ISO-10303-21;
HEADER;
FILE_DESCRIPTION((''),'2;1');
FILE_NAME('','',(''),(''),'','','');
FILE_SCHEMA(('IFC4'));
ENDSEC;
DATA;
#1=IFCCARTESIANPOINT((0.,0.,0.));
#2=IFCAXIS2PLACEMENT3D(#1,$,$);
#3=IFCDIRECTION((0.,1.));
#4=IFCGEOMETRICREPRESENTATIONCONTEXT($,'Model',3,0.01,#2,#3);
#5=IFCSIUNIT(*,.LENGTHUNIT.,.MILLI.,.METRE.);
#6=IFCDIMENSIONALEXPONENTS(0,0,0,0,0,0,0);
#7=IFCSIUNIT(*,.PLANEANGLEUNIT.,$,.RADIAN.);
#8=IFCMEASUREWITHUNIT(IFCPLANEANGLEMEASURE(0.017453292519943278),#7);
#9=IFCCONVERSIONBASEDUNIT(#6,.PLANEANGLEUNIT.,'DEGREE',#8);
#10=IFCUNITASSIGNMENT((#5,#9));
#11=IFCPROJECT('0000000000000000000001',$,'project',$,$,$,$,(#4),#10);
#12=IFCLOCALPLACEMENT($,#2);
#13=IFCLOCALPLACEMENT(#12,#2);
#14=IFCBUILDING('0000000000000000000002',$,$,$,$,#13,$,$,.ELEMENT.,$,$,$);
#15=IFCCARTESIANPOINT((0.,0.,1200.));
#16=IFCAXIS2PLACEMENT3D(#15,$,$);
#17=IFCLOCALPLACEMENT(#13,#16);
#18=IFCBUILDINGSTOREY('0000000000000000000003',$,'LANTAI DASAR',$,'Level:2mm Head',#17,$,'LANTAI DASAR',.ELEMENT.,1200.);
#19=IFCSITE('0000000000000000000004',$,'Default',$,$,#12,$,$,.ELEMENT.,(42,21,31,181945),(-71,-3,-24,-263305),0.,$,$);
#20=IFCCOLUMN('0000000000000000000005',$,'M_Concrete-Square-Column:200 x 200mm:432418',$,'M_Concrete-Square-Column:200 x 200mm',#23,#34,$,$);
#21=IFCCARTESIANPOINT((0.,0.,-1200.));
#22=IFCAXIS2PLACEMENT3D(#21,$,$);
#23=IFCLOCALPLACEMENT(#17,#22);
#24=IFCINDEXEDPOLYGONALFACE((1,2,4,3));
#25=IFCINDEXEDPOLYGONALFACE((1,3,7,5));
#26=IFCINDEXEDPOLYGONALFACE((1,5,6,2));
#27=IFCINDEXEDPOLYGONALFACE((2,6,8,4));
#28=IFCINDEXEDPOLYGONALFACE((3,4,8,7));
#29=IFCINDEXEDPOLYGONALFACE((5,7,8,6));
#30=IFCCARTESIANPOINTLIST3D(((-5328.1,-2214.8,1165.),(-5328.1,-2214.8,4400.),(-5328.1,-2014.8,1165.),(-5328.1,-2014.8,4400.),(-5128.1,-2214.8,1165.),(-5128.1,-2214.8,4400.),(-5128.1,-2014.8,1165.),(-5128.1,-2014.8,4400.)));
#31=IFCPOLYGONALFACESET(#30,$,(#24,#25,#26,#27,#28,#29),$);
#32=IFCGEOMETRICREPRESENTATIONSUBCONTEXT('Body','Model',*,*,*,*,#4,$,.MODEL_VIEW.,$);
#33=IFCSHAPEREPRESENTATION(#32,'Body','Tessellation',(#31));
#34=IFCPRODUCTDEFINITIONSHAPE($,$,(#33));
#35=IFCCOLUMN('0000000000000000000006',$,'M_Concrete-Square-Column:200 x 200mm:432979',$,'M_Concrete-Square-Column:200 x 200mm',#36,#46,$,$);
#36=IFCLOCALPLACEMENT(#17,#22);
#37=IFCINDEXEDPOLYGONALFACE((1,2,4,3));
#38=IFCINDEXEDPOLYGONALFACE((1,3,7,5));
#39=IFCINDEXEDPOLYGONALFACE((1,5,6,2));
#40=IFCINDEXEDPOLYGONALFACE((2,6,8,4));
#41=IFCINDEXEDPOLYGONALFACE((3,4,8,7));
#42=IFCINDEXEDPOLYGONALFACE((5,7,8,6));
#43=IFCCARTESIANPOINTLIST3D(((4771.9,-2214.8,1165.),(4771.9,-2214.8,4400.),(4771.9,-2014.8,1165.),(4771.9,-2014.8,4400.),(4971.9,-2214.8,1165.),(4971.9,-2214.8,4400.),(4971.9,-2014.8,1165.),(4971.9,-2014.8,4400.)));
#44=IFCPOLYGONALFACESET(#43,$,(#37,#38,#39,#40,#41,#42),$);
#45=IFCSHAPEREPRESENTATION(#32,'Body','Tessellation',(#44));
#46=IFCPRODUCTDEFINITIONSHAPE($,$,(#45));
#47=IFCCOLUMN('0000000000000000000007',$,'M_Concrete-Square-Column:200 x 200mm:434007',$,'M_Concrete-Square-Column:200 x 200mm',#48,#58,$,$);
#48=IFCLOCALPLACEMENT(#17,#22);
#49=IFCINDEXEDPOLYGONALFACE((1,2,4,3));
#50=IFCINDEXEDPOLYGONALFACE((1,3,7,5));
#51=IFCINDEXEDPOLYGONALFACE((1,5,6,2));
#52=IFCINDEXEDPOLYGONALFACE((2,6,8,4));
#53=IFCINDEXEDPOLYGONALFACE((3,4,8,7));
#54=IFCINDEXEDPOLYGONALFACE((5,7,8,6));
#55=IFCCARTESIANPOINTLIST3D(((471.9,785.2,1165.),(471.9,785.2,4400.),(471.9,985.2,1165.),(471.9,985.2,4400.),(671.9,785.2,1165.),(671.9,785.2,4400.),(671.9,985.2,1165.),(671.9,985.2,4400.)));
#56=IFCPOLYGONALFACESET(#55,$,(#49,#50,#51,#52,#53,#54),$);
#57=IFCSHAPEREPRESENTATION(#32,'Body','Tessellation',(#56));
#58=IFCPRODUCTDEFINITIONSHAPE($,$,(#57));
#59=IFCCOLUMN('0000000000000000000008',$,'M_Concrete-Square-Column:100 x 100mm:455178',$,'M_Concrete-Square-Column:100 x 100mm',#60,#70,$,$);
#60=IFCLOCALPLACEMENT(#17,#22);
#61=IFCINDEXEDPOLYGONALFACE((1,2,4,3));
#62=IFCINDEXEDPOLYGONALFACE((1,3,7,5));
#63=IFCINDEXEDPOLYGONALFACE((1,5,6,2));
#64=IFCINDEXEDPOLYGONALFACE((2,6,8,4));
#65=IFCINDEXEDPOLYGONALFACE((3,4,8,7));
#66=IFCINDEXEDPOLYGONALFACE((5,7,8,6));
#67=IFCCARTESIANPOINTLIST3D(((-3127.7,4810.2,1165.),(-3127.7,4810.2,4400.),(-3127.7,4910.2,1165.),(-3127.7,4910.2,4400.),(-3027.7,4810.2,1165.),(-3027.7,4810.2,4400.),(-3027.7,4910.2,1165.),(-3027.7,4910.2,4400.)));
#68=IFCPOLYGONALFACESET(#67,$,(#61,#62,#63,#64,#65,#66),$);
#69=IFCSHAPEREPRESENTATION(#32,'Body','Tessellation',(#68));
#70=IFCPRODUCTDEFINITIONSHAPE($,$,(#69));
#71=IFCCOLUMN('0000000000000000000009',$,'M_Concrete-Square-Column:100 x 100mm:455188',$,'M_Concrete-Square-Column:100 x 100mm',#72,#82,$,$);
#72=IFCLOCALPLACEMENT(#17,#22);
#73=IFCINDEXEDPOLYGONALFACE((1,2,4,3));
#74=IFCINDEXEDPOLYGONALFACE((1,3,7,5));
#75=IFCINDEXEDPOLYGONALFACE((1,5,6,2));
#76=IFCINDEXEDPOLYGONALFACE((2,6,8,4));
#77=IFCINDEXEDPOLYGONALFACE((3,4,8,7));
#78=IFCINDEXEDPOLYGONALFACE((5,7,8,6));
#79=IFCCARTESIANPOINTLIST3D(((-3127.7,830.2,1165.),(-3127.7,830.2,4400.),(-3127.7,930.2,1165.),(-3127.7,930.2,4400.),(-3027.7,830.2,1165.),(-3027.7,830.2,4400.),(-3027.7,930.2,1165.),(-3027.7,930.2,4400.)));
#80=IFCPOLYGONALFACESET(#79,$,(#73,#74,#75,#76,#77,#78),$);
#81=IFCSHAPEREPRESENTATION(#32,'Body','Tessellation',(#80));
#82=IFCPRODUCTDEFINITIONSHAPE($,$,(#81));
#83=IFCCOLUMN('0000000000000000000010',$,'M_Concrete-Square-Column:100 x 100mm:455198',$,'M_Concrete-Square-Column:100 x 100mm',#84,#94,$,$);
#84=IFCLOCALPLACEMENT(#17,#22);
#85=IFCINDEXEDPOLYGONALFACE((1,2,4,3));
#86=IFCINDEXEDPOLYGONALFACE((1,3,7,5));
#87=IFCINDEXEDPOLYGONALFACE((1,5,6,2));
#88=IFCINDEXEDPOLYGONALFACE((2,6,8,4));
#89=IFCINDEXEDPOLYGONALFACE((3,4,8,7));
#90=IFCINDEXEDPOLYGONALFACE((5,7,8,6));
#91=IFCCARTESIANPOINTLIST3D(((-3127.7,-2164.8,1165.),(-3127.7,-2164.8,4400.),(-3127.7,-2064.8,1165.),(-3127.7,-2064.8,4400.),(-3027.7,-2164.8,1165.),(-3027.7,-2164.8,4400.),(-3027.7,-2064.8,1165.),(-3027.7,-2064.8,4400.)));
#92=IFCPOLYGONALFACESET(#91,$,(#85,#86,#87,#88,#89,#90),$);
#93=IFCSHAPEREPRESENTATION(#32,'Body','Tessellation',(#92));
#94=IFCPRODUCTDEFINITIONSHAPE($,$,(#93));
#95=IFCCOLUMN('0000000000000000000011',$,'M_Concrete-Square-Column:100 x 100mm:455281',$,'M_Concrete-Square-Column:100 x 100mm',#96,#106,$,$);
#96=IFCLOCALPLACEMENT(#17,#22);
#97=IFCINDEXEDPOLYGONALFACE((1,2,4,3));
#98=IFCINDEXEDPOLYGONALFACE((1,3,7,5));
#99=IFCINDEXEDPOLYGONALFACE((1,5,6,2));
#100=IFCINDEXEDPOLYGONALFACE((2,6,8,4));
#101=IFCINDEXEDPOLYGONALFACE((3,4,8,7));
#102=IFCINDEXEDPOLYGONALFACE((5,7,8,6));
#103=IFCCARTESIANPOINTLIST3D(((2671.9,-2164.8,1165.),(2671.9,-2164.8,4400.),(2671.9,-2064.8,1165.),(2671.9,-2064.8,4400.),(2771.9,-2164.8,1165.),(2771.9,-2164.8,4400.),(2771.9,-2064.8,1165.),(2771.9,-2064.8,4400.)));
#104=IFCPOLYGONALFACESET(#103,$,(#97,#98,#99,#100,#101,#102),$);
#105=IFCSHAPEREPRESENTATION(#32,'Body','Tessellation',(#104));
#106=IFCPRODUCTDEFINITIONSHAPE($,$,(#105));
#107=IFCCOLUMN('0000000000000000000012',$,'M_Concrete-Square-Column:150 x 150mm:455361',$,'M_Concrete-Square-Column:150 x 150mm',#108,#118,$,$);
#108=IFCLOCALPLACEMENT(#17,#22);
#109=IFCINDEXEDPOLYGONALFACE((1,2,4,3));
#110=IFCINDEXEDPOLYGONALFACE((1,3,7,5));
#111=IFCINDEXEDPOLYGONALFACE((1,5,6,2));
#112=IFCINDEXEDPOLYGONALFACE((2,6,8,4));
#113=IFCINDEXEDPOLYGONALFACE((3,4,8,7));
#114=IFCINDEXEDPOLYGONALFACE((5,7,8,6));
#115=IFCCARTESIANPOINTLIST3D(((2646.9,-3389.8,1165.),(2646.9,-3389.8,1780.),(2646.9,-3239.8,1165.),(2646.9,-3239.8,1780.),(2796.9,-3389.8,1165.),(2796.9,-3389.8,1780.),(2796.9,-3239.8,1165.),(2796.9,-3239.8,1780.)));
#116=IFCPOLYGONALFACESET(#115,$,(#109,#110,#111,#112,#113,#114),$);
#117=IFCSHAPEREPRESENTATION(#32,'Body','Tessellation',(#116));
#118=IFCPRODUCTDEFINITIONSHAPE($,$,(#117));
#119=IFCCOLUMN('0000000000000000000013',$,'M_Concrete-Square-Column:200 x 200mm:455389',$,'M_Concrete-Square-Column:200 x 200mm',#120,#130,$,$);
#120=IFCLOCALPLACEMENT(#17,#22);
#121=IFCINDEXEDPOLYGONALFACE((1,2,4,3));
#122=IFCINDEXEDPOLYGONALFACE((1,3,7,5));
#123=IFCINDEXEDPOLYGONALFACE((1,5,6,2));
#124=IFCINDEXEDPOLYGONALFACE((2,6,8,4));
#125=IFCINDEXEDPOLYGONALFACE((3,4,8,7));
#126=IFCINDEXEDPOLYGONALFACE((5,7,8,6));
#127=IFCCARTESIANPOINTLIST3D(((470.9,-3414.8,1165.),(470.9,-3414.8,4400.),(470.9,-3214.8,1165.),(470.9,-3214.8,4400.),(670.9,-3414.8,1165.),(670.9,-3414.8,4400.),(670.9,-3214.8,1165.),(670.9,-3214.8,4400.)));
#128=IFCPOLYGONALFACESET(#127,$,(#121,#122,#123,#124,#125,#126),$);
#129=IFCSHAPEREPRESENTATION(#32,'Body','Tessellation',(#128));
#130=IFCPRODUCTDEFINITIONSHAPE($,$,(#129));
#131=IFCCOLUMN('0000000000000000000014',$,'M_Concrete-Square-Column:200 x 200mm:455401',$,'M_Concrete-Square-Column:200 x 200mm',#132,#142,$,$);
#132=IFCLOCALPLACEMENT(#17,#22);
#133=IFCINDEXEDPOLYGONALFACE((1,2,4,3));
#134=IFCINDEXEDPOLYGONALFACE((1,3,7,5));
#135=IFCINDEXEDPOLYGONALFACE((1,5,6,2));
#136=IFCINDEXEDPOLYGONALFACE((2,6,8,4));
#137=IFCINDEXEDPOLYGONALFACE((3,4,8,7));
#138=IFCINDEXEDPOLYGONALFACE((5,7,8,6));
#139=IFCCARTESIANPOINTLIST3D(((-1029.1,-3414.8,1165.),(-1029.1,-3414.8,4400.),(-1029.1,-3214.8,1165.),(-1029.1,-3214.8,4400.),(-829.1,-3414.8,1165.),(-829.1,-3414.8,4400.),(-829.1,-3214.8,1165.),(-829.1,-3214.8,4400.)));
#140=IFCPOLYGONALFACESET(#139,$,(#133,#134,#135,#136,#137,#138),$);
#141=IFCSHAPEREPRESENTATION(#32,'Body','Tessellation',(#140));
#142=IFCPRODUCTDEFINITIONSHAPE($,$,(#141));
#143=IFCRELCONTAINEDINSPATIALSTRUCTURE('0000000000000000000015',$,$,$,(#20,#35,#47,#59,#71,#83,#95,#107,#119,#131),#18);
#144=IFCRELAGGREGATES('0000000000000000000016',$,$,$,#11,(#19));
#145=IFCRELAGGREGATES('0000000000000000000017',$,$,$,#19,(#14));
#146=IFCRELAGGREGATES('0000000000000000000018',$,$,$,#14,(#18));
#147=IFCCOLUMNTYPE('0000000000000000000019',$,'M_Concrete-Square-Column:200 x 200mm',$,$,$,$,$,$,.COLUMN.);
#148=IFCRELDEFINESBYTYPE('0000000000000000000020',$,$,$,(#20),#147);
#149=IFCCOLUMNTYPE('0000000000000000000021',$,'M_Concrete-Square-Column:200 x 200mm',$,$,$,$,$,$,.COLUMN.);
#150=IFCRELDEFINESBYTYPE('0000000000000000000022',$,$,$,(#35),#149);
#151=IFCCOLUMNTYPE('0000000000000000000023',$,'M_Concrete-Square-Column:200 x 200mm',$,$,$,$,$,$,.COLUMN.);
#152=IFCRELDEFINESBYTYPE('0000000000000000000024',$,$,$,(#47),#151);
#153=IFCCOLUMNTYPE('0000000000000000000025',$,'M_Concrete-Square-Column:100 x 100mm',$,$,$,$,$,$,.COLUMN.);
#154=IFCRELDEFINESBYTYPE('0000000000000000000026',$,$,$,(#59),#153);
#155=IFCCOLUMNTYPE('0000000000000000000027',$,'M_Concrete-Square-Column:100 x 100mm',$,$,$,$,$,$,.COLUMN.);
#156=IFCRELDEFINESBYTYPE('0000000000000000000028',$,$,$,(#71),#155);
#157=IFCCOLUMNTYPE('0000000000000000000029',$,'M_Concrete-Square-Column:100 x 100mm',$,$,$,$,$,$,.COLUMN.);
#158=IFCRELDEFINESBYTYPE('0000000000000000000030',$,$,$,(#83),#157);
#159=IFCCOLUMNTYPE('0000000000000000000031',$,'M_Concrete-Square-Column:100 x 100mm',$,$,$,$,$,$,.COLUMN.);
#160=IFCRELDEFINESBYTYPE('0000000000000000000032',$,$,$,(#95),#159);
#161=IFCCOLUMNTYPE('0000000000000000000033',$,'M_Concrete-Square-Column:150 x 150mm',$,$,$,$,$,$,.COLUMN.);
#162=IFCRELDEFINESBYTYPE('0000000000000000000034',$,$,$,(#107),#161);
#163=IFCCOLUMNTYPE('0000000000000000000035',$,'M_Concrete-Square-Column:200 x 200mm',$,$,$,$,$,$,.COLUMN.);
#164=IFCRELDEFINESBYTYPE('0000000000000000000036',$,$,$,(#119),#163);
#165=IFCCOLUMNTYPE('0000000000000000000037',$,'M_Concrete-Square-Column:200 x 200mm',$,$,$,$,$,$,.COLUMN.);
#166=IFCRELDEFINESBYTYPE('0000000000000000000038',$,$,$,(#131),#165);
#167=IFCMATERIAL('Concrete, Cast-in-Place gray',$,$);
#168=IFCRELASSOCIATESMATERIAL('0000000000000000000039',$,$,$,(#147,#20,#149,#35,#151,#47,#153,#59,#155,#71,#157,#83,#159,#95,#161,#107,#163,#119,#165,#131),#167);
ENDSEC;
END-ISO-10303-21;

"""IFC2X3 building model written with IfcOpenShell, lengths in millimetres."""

from ifc_helpers import new_model, entity, si_unit, converted_unit, direction, frame, frame_2d, origin, origin_2d_with_axis, place, context, subcontext, project, spatial, rectangle, extrude, source, transform, mapped, material, type_object, type_shapes, element, save


model = new_model("IFC2X3")

# Units and contexts
model_context = context("Model", 3, precision=0.01, world=origin(), true_north=direction((0.0, 1.0)))
body_context = subcontext(model_context, "Body", "Model", "MODEL_VIEW")
ifc_project = project(units=[si_unit("LENGTHUNIT", "METRE", prefix="MILLI"), converted_unit("PLANEANGLEUNIT", "DEGREE", entity("IfcPlaneAngleMeasure", 0.017453292519943278), si_unit("PLANEANGLEUNIT", "RADIAN"), dimensions=[0, 0, 0, 0, 0, 0, 0])], contexts=[model_context])

# Site, building, storey
site_placement = place(None, origin())
site = spatial("IfcSite", under=ifc_project, at=site_placement, Name="Default", CompositionType="ELEMENT", RefLatitude=(42, 21, 31, 181945), RefLongitude=(-71, -3, -24, -263305), RefElevation=0.0)
building_placement = place(site_placement, origin())
building = spatial("IfcBuilding", under=site, at=building_placement, CompositionType="ELEMENT")
storey_placement = place(building_placement, frame((0.0, 0.0, 1200.0)))
storey = spatial("IfcBuildingStorey", under=building, at=storey_placement, Name="LANTAI DASAR", ObjectType="Level:2mm Head", LongName="LANTAI DASAR", CompositionType="ELEMENT", Elevation=1200.0)

# Columns
ifc_material = material(Name="Concrete, Cast-in-Place gray")
column_type_1 = type_object("IfcColumnType", Name="M_Concrete-Square-Column:200 x 200mm", PredefinedType="COLUMN", material=ifc_material)
shared_shape_1 = source(origin(), body_context, "Body", "SweptSolid", [
    extrude(rectangle(XDim=200.0, YDim=200.0, at=origin_2d_with_axis()), frame((-5228.1, -2114.8, 1165.0), z_axis=(0.0, 0.0, 1.0), x_axis=(-1.0, 0.0, 0.0)), (0.0, 0.0, 1.0), 3235.0),
])
type_shapes(column_type_1, [shared_shape_1])
column_1_placement = place(storey_placement, frame((0.0, 0.0, -1200.0)))
element("IfcColumn", 1, at=column_1_placement, inside=storey, type_object=column_type_1, material=ifc_material, Name="M_Concrete-Square-Column:200 x 200mm:432418", ObjectType="M_Concrete-Square-Column:200 x 200mm", context=body_context, shape_type="MappedRepresentation", body=[
    mapped(shared_shape_1, transform((0.0, 0.0, 0.0), scale=1.0)),
])
column_type_2 = type_object("IfcColumnType", Name="M_Concrete-Square-Column:200 x 200mm", PredefinedType="COLUMN", material=ifc_material)
shared_shape_2 = source(origin(), body_context, "Body", "SweptSolid", [
    extrude(rectangle(XDim=200.0, YDim=200.0, at=frame_2d((0.0, 0.0), x_axis=(1.0, 0.0))), frame((4871.9, -2114.8, 1165.0), z_axis=(0.0, 0.0, 1.0), x_axis=(-1.0, 0.0, 0.0)), (0.0, 0.0, 1.0), 3235.0),
])
type_shapes(column_type_2, [shared_shape_2])
column_2_placement = place(storey_placement, frame((0.0, 0.0, -1200.0)))
element("IfcColumn", 2, at=column_2_placement, inside=storey, type_object=column_type_2, material=ifc_material, Name="M_Concrete-Square-Column:200 x 200mm:432979", ObjectType="M_Concrete-Square-Column:200 x 200mm", context=body_context, shape_type="MappedRepresentation", body=[
    mapped(shared_shape_2, transform((0.0, 0.0, 0.0), scale=1.0)),
])
column_type_3 = type_object("IfcColumnType", Name="M_Concrete-Square-Column:200 x 200mm", PredefinedType="COLUMN", material=ifc_material)
shared_shape_3 = source(origin(), body_context, "Body", "SweptSolid", [
    extrude(rectangle(XDim=200.0, YDim=200.0, at=origin_2d_with_axis()), frame((571.9, 885.2, 1165.0), z_axis=(0.0, 0.0, 1.0), x_axis=(-1.0, 0.0, 0.0)), (0.0, 0.0, 1.0), 3235.0),
])
type_shapes(column_type_3, [shared_shape_3])
column_3_placement = place(storey_placement, frame((0.0, 0.0, -1200.0)))
element("IfcColumn", 3, at=column_3_placement, inside=storey, type_object=column_type_3, material=ifc_material, Name="M_Concrete-Square-Column:200 x 200mm:434007", ObjectType="M_Concrete-Square-Column:200 x 200mm", context=body_context, shape_type="MappedRepresentation", body=[
    mapped(shared_shape_3, transform((0.0, 0.0, 0.0), scale=1.0)),
])
column_type_4 = type_object("IfcColumnType", Name="M_Concrete-Square-Column:100 x 100mm", PredefinedType="COLUMN", material=ifc_material)
shared_shape_4 = source(origin(), body_context, "Body", "SweptSolid", [
    extrude(rectangle(XDim=100.0, YDim=100.0, at=frame_2d((0.0, 0.0), x_axis=(1.0, 0.0))), frame((-3077.7, 4860.2, 1165.0), z_axis=(0.0, 0.0, 1.0), x_axis=(-1.0, 0.0, 0.0)), (0.0, 0.0, 1.0), 3235.0),
])
type_shapes(column_type_4, [shared_shape_4])
column_4_placement = place(storey_placement, frame((0.0, 0.0, -1200.0)))
element("IfcColumn", 4, at=column_4_placement, inside=storey, type_object=column_type_4, material=ifc_material, Name="M_Concrete-Square-Column:100 x 100mm:455178", ObjectType="M_Concrete-Square-Column:100 x 100mm", context=body_context, shape_type="MappedRepresentation", body=[
    mapped(shared_shape_4, transform((0.0, 0.0, 0.0), scale=1.0)),
])
column_type_5 = type_object("IfcColumnType", Name="M_Concrete-Square-Column:100 x 100mm", PredefinedType="COLUMN", material=ifc_material)
shared_shape_5 = source(origin(), body_context, "Body", "SweptSolid", [
    extrude(rectangle(XDim=100.0, YDim=100.0, at=origin_2d_with_axis()), frame((-3077.7, 880.2, 1165.0), z_axis=(0.0, 0.0, 1.0), x_axis=(-1.0, 0.0, 0.0)), (0.0, 0.0, 1.0), 3235.0),
])
type_shapes(column_type_5, [shared_shape_5])
column_5_placement = place(storey_placement, frame((0.0, 0.0, -1200.0)))
element("IfcColumn", 5, at=column_5_placement, inside=storey, type_object=column_type_5, material=ifc_material, Name="M_Concrete-Square-Column:100 x 100mm:455188", ObjectType="M_Concrete-Square-Column:100 x 100mm", context=body_context, shape_type="MappedRepresentation", body=[
    mapped(shared_shape_5, transform((0.0, 0.0, 0.0), scale=1.0)),
])
column_type_6 = type_object("IfcColumnType", Name="M_Concrete-Square-Column:100 x 100mm", PredefinedType="COLUMN", material=ifc_material)
shared_shape_6 = source(origin(), body_context, "Body", "SweptSolid", [
    extrude(rectangle(XDim=100.0, YDim=100.0, at=origin_2d_with_axis()), frame((-3077.7, -2114.8, 1165.0), z_axis=(0.0, 0.0, 1.0), x_axis=(-1.0, 0.0, 0.0)), (0.0, 0.0, 1.0), 3235.0),
])
type_shapes(column_type_6, [shared_shape_6])
column_6_placement = place(storey_placement, frame((0.0, 0.0, -1200.0)))
element("IfcColumn", 6, at=column_6_placement, inside=storey, type_object=column_type_6, material=ifc_material, Name="M_Concrete-Square-Column:100 x 100mm:455198", ObjectType="M_Concrete-Square-Column:100 x 100mm", context=body_context, shape_type="MappedRepresentation", body=[
    mapped(shared_shape_6, transform((0.0, 0.0, 0.0), scale=1.0)),
])
column_type_7 = type_object("IfcColumnType", Name="M_Concrete-Square-Column:100 x 100mm", PredefinedType="COLUMN", material=ifc_material)
shared_shape_7 = source(origin(), body_context, "Body", "SweptSolid", [
    extrude(rectangle(XDim=100.0, YDim=100.0, at=origin_2d_with_axis()), frame((2721.9, -2114.8, 1165.0), z_axis=(0.0, 0.0, 1.0), x_axis=(-1.0, 0.0, 0.0)), (0.0, 0.0, 1.0), 3235.0),
])
type_shapes(column_type_7, [shared_shape_7])
column_7_placement = place(storey_placement, frame((0.0, 0.0, -1200.0)))
element("IfcColumn", 7, at=column_7_placement, inside=storey, type_object=column_type_7, material=ifc_material, Name="M_Concrete-Square-Column:100 x 100mm:455281", ObjectType="M_Concrete-Square-Column:100 x 100mm", context=body_context, shape_type="MappedRepresentation", body=[
    mapped(shared_shape_7, transform((0.0, 0.0, 0.0), scale=1.0)),
])
column_type_8 = type_object("IfcColumnType", Name="M_Concrete-Square-Column:150 x 150mm", PredefinedType="COLUMN", material=ifc_material)
shared_shape_8 = source(origin(), body_context, "Body", "SweptSolid", [
    extrude(rectangle(XDim=150.0, YDim=150.0, at=frame_2d((0.0, 0.0), x_axis=(1.0, 0.0))), frame((2721.9, -3314.8, 1165.0), z_axis=(0.0, 0.0, 1.0), x_axis=(-1.0, 0.0, 0.0)), (0.0, 0.0, 1.0), 615.0),
])
type_shapes(column_type_8, [shared_shape_8])
column_8_placement = place(storey_placement, frame((0.0, 0.0, -1200.0)))
element("IfcColumn", 8, at=column_8_placement, inside=storey, type_object=column_type_8, material=ifc_material, Name="M_Concrete-Square-Column:150 x 150mm:455361", ObjectType="M_Concrete-Square-Column:150 x 150mm", context=body_context, shape_type="MappedRepresentation", body=[
    mapped(shared_shape_8, transform((0.0, 0.0, 0.0), scale=1.0)),
])
column_type_9 = type_object("IfcColumnType", Name="M_Concrete-Square-Column:200 x 200mm", PredefinedType="COLUMN", material=ifc_material)
shared_shape_9 = source(origin(), body_context, "Body", "SweptSolid", [
    extrude(rectangle(XDim=200.0, YDim=200.0, at=origin_2d_with_axis()), frame((570.9, -3314.8, 1165.0), z_axis=(0.0, 0.0, 1.0), x_axis=(-1.0, 0.0, 0.0)), (0.0, 0.0, 1.0), 3235.0),
])
type_shapes(column_type_9, [shared_shape_9])
column_9_placement = place(storey_placement, frame((0.0, 0.0, -1200.0)))
element("IfcColumn", 9, at=column_9_placement, inside=storey, type_object=column_type_9, material=ifc_material, Name="M_Concrete-Square-Column:200 x 200mm:455389", ObjectType="M_Concrete-Square-Column:200 x 200mm", context=body_context, shape_type="MappedRepresentation", body=[
    mapped(shared_shape_9, transform((0.0, 0.0, 0.0), scale=1.0)),
])
column_type_10 = type_object("IfcColumnType", Name="M_Concrete-Square-Column:200 x 200mm", PredefinedType="COLUMN", material=ifc_material)
shared_shape_10 = source(origin(), body_context, "Body", "SweptSolid", [
    extrude(rectangle(XDim=200.0, YDim=200.0, at=origin_2d_with_axis()), frame((-929.1, -3314.8, 1165.0), z_axis=(0.0, 0.0, 1.0), x_axis=(-1.0, 0.0, 0.0)), (0.0, 0.0, 1.0), 3235.0),
])
type_shapes(column_type_10, [shared_shape_10])
column_10_placement = place(storey_placement, frame((0.0, 0.0, -1200.0)))
element("IfcColumn", 10, at=column_10_placement, inside=storey, type_object=column_type_10, material=ifc_material, Name="M_Concrete-Square-Column:200 x 200mm:455401", ObjectType="M_Concrete-Square-Column:200 x 200mm", context=body_context, shape_type="MappedRepresentation", body=[
    mapped(shared_shape_10, transform((0.0, 0.0, 0.0), scale=1.0)),
])

save(model, "model.ifc")
